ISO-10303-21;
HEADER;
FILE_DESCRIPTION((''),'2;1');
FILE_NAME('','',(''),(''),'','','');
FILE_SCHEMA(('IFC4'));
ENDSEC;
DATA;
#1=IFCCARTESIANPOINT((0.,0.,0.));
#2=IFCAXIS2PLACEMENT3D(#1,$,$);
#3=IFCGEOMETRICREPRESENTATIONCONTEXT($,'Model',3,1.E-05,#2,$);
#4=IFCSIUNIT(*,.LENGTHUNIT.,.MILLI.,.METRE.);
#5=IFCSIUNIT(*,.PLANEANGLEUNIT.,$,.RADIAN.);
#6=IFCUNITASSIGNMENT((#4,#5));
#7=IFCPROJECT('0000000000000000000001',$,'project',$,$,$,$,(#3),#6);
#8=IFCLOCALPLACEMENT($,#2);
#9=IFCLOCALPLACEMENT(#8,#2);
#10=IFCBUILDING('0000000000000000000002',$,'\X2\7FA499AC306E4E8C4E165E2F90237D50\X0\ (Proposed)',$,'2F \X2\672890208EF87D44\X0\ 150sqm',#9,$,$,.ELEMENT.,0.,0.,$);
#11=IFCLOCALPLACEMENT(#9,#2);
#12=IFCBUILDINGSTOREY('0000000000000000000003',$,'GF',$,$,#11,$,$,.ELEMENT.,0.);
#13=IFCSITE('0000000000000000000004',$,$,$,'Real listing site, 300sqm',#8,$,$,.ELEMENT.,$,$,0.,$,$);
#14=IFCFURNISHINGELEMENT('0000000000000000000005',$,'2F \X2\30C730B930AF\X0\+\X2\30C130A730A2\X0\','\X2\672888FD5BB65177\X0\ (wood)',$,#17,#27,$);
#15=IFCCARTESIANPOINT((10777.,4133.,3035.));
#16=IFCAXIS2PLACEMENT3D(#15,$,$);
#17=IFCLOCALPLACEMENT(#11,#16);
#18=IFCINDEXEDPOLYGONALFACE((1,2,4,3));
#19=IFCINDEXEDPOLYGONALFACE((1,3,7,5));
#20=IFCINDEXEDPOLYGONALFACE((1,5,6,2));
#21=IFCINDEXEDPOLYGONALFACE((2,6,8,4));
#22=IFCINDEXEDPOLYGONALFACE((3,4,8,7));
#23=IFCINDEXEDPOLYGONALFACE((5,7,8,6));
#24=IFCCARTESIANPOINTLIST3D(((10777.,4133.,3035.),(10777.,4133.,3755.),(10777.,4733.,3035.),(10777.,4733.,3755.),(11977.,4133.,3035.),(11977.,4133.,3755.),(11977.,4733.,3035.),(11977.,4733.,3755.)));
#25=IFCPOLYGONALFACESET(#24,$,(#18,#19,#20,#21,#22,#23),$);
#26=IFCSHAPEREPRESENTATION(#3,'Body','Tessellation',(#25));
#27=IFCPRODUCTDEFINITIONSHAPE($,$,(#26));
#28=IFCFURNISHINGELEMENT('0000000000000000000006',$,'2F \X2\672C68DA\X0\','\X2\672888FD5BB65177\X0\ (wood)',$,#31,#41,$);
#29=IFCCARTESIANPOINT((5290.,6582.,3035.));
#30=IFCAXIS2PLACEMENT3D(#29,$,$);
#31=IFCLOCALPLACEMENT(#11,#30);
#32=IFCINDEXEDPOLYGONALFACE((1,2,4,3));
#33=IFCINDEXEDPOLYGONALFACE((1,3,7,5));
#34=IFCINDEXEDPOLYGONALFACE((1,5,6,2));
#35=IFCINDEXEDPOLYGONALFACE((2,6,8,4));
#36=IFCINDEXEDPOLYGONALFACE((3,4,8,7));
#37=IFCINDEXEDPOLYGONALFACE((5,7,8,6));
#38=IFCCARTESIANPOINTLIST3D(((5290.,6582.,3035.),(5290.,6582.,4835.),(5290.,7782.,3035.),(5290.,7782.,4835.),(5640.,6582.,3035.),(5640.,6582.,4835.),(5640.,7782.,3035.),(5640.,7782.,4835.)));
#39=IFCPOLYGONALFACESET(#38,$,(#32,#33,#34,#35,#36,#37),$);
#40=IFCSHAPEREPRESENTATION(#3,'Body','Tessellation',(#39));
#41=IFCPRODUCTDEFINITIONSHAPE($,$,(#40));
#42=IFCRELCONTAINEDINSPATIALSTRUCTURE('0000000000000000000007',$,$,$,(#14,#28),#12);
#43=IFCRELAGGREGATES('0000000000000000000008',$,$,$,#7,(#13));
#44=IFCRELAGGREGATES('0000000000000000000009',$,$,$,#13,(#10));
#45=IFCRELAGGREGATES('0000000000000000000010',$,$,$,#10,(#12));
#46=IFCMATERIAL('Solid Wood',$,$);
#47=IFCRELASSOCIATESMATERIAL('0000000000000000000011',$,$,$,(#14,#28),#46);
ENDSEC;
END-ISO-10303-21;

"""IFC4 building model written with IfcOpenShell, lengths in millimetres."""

from ifc_helpers import new_model, si_unit, frame, frame_2d, origin, place, context, project, spatial, rectangle, extrude, material, element, save


model = new_model("IFC4")

# Units and contexts
model_context = context("Model", 3, precision=1e-05, world=origin())
ifc_project = project(units=[si_unit("LENGTHUNIT", "METRE", prefix="MILLI"), si_unit("PLANEANGLEUNIT", "RADIAN")], contexts=[model_context])

# Site, building, storey
site_placement = place(None, origin())
site = spatial("IfcSite", under=ifc_project, at=site_placement, ObjectType="Real listing site, 300sqm", CompositionType="ELEMENT", RefElevation=0.0)
building_placement = place(site_placement, origin())
building = spatial("IfcBuilding", under=site, at=building_placement, Name="群馬の二世帯連結 (Proposed)", ObjectType="2F 木造軸組 150sqm", CompositionType="ELEMENT", ElevationOfRefHeight=0.0, ElevationOfTerrain=0.0)
storey_placement = place(building_placement, origin())
storey = spatial("IfcBuildingStorey", under=building, at=storey_placement, Name="GF", CompositionType="ELEMENT", Elevation=0.0)

# Shared definitions
ifc_material_1 = material(Name="Solid Wood")

# Furnishing elements
furnishing_1_placement = place(storey_placement, frame((10777.0, 4133.0, 3035.0)))
element("IfcFurnishingElement", 1, at=furnishing_1_placement, inside=storey, material=ifc_material_1, Name="2F デスク+チェア", Description="木製家具 (wood)", context=model_context, shape_type="SweptSolid", body=[
    extrude(rectangle(XDim=1200.0, YDim=600.0, at=frame_2d((600.0, 300.0))), frame((10777.0, 4133.0, 3035.0)), (0.0, 0.0, 1.0), 720.0),
])
furnishing_2_placement = place(storey_placement, frame((5290.0, 6582.0, 3035.0)))
element("IfcFurnishingElement", 2, at=furnishing_2_placement, inside=storey, material=ifc_material_1, Name="2F 本棚", Description="木製家具 (wood)", context=model_context, shape_type="SweptSolid", body=[
    extrude(rectangle(XDim=350.0, YDim=1200.0, at=frame_2d((175.0, 600.0))), frame((5290.0, 6582.0, 3035.0)), (0.0, 0.0, 1.0), 1800.0),
])

save(model, "model.ifc")
